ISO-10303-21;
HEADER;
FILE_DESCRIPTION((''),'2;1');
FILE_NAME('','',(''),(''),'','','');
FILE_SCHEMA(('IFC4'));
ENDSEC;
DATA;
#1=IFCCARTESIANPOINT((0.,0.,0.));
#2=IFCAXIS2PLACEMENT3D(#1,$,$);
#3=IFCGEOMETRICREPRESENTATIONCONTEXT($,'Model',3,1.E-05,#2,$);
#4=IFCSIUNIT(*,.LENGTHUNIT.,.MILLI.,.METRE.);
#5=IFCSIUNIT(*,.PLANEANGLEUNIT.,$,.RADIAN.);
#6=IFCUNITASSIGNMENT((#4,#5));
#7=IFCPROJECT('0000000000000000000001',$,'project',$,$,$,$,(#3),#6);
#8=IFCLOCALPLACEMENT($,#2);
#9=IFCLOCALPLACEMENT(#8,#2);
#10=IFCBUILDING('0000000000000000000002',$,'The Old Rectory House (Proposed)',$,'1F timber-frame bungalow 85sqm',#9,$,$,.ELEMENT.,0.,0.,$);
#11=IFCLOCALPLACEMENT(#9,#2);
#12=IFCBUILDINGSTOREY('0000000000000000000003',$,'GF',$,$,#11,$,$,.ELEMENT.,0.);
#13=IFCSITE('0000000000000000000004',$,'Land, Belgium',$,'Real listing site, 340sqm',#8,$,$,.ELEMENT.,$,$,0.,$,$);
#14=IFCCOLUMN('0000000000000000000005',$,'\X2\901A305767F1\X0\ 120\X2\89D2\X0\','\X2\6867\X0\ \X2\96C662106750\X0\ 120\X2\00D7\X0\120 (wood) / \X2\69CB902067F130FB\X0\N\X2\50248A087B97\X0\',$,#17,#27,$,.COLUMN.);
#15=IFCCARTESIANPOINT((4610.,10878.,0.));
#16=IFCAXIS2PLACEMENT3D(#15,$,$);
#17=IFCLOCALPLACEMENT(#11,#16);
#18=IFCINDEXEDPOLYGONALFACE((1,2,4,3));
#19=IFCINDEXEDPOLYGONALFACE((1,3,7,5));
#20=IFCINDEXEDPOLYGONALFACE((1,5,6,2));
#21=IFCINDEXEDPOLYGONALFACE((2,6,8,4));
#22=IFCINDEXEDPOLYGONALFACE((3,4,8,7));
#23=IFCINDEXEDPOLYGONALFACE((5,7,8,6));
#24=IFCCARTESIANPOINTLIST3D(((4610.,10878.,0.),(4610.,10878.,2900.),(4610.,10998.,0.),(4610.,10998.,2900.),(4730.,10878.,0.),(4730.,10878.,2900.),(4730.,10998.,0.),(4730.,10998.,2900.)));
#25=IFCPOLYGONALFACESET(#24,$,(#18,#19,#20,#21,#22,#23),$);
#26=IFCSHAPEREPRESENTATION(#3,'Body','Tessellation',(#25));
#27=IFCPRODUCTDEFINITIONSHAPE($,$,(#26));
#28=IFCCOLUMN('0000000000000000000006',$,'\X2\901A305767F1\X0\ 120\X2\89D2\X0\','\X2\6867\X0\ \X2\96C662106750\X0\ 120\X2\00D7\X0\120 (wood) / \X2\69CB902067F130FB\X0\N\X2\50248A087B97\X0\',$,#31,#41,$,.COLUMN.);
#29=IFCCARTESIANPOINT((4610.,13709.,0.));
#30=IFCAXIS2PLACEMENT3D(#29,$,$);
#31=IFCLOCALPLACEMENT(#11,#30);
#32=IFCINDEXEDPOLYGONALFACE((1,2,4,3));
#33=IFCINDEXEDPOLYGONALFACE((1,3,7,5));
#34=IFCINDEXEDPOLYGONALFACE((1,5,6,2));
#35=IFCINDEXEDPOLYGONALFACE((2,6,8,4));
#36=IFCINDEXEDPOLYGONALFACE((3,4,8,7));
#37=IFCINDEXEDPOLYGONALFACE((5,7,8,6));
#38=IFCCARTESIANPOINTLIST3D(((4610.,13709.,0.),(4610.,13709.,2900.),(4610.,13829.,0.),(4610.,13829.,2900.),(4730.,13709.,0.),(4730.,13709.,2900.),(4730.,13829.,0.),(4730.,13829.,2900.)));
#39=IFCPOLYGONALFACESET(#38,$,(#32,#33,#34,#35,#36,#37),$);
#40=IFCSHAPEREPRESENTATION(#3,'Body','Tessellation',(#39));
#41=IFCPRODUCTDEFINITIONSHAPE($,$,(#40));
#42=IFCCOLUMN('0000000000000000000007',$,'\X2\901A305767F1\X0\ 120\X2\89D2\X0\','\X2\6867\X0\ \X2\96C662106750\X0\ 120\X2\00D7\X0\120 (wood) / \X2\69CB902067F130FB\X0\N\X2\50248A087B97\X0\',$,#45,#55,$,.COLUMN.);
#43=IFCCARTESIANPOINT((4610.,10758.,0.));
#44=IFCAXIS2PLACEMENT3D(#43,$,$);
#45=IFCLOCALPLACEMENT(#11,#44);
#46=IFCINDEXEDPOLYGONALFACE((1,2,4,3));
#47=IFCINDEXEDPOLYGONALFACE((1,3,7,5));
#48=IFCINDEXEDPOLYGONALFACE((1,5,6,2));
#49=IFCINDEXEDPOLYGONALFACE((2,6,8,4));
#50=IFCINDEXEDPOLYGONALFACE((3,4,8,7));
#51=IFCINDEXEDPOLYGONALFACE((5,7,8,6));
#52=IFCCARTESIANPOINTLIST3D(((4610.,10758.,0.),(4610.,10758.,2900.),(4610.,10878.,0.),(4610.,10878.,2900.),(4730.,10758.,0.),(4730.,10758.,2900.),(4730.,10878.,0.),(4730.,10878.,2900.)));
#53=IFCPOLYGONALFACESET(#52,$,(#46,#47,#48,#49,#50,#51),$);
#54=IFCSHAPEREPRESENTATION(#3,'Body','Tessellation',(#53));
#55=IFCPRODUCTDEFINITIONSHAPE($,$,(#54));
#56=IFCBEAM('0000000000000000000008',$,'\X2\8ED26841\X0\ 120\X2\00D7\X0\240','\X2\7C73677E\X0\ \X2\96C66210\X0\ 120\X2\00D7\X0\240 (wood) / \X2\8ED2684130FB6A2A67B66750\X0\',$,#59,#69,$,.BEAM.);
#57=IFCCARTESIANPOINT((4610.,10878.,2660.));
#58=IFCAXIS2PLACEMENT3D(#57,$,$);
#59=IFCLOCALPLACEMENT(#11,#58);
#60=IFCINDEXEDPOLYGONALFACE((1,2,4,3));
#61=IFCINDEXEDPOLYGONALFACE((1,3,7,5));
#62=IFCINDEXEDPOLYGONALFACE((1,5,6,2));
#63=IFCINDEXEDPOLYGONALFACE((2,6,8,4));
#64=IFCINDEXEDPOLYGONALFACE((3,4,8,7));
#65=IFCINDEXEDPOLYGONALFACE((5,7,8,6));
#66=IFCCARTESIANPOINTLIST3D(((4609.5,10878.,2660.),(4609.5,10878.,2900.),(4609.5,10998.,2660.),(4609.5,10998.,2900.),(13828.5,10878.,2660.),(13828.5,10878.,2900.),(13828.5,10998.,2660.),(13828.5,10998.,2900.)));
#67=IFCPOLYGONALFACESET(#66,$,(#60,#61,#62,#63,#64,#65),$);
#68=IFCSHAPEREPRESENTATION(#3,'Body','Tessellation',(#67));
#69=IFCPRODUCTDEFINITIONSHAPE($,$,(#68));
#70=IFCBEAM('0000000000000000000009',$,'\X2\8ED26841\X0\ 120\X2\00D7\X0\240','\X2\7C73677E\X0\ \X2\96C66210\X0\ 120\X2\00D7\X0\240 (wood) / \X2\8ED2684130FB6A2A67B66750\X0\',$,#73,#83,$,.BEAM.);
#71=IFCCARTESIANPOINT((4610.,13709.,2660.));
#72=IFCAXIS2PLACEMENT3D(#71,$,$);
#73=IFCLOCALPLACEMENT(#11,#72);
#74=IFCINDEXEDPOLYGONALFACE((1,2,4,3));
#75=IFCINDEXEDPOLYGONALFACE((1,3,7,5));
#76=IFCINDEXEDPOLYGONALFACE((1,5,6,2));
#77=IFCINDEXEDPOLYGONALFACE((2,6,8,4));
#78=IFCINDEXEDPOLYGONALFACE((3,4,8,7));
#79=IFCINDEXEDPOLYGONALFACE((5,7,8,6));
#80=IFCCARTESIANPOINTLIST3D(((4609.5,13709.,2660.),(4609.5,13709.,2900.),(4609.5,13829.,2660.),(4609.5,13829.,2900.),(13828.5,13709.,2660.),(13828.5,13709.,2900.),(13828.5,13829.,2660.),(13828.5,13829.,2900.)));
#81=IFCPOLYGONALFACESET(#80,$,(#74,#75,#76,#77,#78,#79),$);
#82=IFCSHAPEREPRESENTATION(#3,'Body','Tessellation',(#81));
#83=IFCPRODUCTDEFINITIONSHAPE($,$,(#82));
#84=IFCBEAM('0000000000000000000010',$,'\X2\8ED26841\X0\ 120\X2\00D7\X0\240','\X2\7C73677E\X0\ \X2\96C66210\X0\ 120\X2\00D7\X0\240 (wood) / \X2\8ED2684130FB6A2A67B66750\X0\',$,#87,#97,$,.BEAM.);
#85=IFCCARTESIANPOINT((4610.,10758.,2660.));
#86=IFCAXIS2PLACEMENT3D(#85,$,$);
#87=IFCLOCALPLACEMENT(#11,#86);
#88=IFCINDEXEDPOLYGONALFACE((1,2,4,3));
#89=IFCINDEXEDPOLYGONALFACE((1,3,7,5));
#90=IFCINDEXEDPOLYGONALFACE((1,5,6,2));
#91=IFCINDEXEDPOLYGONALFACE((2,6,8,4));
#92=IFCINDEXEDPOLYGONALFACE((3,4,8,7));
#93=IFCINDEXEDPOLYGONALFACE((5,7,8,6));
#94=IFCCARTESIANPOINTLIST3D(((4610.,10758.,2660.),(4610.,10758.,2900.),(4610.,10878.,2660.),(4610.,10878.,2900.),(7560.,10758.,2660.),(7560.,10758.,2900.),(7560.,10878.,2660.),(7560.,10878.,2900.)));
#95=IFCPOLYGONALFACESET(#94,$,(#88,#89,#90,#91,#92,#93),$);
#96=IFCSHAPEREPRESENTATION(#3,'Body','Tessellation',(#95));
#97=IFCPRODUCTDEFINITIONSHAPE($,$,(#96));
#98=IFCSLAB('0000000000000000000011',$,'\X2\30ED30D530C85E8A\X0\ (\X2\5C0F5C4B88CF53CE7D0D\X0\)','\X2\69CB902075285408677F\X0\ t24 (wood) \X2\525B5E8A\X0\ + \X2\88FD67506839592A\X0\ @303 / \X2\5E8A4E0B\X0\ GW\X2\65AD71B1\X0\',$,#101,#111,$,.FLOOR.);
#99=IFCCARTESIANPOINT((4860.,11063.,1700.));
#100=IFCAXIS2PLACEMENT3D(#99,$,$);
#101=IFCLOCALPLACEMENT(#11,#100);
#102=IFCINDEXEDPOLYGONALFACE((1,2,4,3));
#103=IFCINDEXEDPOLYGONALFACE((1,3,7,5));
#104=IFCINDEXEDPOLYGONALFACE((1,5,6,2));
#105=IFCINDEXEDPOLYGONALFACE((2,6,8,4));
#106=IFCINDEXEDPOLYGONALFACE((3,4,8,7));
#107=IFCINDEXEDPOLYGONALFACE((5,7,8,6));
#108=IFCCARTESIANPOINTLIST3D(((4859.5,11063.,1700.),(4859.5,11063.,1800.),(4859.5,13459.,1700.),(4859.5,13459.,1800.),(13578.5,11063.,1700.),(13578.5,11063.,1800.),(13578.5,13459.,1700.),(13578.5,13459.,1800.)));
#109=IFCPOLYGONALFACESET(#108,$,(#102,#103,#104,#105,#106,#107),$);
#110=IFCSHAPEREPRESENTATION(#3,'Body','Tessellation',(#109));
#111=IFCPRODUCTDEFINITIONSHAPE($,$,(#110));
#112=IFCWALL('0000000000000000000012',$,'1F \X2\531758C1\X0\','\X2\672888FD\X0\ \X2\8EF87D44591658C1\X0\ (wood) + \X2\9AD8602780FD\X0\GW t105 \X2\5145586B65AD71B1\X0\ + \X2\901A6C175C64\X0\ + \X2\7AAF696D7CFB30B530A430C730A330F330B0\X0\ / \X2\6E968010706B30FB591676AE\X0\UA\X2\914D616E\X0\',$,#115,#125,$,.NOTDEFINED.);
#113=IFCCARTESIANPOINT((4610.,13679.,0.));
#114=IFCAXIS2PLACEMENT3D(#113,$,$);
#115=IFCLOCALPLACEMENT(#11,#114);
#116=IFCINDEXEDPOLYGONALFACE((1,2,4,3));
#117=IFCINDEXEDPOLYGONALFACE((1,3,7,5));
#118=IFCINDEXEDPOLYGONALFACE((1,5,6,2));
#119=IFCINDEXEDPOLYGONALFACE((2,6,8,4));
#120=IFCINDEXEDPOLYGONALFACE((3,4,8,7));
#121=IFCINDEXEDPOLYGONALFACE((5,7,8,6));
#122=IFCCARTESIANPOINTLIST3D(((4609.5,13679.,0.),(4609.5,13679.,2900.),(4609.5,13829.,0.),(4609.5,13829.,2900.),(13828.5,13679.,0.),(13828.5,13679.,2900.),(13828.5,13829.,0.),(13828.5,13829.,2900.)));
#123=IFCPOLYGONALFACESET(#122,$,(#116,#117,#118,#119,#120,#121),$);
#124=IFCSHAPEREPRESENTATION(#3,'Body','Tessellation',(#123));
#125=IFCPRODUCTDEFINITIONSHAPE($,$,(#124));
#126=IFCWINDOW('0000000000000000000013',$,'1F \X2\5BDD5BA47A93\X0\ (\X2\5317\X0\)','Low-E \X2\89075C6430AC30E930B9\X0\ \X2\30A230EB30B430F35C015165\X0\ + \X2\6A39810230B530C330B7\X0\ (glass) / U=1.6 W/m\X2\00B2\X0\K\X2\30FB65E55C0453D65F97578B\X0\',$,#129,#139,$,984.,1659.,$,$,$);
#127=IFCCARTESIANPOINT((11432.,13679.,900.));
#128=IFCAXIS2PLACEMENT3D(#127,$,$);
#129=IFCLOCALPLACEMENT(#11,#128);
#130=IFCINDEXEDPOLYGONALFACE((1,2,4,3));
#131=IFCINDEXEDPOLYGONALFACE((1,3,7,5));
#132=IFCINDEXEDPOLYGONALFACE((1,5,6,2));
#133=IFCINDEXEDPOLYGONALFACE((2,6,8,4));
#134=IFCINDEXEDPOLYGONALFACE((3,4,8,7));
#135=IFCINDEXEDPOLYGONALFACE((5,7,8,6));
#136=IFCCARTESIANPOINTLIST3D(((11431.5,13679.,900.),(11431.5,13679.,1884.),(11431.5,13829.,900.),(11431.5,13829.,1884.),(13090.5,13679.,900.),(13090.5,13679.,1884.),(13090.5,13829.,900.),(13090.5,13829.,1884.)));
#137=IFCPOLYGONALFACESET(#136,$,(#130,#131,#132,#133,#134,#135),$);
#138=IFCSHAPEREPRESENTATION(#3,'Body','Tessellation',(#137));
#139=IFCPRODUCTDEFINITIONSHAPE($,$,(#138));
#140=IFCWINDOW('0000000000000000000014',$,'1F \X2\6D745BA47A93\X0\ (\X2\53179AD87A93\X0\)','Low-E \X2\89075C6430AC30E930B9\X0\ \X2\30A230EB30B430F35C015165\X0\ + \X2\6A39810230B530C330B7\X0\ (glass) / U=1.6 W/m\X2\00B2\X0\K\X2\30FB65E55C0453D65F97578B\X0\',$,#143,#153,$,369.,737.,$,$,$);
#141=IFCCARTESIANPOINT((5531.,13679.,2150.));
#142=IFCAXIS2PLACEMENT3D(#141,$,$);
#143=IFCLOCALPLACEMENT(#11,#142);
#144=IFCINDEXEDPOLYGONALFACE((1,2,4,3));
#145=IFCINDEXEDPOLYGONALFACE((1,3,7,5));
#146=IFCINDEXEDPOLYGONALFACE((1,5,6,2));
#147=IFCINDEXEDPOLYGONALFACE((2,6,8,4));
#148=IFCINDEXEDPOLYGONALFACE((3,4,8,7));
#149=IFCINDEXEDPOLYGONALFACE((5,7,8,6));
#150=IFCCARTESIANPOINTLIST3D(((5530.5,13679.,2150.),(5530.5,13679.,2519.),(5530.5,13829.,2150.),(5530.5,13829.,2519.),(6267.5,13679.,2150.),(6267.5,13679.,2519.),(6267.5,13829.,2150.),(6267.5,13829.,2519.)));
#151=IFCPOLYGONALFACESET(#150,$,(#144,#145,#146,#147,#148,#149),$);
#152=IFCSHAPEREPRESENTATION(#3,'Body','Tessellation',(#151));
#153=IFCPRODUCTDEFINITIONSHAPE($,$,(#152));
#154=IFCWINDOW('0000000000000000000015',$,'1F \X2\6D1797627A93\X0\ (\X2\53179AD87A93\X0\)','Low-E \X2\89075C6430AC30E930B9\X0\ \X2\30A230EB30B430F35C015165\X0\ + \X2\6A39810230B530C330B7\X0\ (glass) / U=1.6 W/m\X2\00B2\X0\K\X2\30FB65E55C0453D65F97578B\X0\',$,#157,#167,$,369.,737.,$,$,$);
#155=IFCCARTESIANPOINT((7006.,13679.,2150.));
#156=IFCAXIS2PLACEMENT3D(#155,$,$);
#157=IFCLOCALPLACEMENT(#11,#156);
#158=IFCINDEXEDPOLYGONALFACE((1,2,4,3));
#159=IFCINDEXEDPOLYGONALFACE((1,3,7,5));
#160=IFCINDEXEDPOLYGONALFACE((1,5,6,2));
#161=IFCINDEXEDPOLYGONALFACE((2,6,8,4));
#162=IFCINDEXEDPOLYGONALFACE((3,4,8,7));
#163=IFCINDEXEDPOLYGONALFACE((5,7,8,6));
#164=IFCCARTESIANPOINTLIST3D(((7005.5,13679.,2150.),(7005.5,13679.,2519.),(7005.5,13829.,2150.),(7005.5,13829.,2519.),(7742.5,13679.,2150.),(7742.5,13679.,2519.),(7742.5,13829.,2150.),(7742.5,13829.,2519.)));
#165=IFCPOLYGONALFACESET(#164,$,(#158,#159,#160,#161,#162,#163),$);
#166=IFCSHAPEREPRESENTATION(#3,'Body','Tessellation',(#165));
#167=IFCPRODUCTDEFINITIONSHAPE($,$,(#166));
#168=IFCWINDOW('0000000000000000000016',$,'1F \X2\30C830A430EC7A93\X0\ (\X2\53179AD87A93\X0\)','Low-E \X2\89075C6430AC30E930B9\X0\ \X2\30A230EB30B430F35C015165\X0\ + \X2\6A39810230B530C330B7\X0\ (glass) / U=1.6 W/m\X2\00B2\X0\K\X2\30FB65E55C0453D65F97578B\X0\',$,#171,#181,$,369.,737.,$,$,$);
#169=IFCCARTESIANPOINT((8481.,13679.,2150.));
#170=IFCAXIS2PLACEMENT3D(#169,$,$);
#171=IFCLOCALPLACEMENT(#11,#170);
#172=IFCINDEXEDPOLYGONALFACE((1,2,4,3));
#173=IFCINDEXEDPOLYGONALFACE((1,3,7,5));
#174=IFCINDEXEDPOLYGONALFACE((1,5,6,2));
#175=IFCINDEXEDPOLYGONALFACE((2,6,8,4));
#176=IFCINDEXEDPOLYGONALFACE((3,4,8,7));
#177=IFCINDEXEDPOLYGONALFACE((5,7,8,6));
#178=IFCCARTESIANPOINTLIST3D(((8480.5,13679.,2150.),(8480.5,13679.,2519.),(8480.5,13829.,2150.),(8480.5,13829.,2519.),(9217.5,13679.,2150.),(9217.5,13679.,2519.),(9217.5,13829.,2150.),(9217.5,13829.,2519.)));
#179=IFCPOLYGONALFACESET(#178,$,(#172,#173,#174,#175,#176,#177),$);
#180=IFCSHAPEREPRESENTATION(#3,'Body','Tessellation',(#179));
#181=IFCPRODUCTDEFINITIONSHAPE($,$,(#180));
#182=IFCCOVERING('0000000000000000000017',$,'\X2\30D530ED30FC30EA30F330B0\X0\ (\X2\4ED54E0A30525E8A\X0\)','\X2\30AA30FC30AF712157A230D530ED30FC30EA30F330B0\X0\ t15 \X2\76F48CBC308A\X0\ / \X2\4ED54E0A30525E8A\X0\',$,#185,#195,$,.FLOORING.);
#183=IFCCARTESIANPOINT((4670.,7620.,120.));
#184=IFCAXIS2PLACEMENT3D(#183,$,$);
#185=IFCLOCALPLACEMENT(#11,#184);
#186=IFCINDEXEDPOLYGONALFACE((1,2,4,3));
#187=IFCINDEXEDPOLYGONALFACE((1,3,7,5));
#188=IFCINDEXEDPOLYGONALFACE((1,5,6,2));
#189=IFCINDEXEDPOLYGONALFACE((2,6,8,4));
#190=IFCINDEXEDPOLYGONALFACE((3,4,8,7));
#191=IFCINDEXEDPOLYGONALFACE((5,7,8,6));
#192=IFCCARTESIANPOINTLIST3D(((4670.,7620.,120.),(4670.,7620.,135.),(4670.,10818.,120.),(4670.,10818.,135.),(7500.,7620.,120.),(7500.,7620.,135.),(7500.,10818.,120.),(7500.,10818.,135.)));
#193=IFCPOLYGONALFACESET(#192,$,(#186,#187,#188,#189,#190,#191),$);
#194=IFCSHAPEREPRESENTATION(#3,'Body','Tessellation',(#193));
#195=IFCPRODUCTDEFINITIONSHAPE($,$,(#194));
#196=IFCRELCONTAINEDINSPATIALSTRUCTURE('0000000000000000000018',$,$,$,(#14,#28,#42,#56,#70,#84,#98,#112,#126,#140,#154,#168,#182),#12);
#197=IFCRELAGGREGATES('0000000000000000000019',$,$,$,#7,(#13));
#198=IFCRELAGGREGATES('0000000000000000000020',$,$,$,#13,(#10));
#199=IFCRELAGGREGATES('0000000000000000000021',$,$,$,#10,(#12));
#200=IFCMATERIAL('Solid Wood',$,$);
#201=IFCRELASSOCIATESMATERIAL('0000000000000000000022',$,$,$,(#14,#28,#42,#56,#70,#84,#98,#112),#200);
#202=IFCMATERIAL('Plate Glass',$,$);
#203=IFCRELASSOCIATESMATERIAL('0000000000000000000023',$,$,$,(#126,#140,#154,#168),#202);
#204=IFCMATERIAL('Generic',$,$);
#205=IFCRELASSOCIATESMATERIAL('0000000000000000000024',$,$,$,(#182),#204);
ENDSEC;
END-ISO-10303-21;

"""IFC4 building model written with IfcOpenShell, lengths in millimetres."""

from ifc_helpers import new_model, si_unit, frame, frame_2d, origin, place, context, project, spatial, rectangle, extrude, material, element, fill, save


model = new_model("IFC4")

# Units and contexts
model_context = context("Model", 3, precision=1e-05, world=origin())
ifc_project = project(units=[si_unit("LENGTHUNIT", "METRE", prefix="MILLI"), si_unit("PLANEANGLEUNIT", "RADIAN")], contexts=[model_context])

# Site, building, storey
site_placement = place(None, origin())
site = spatial("IfcSite", under=ifc_project, at=site_placement, Name="Land, Belgium", ObjectType="Real listing site, 340sqm", CompositionType="ELEMENT", RefElevation=0.0)
building_placement = place(site_placement, origin())
building = spatial("IfcBuilding", under=site, at=building_placement, Name="The Old Rectory House (Proposed)", ObjectType="1F timber-frame bungalow 85sqm", CompositionType="ELEMENT", ElevationOfRefHeight=0.0, ElevationOfTerrain=0.0)
storey_placement = place(building_placement, origin())
storey = spatial("IfcBuildingStorey", under=building, at=storey_placement, Name="GF", CompositionType="ELEMENT", Elevation=0.0)

# Columns
ifc_material_1 = material(Name="Solid Wood")
column_1_placement = place(storey_placement, frame((4610.0, 10878.0, 0.0)))
element("IfcColumn", 1, at=column_1_placement, inside=storey, material=ifc_material_1, Name="通し柱 120角", Description="桧 集成材 120×120 (wood) / 構造柱・N値計算", PredefinedType="COLUMN", context=model_context, shape_type="SweptSolid", body=[
    extrude(rectangle(XDim=120.0, YDim=120.0, at=frame_2d((60.0, 60.0))), frame((4610.0, 10878.0, 0.0)), (0.0, 0.0, 1.0), 2900.0),
])
column_2_placement = place(storey_placement, frame((4610.0, 13709.0, 0.0)))
element("IfcColumn", 2, at=column_2_placement, inside=storey, material=ifc_material_1, Name="通し柱 120角", Description="桧 集成材 120×120 (wood) / 構造柱・N値計算", PredefinedType="COLUMN", context=model_context, shape_type="SweptSolid", body=[
    extrude(rectangle(XDim=120.0, YDim=120.0, at=frame_2d((60.0, 60.0))), frame((4610.0, 13709.0, 0.0)), (0.0, 0.0, 1.0), 2900.0),
])
column_3_placement = place(storey_placement, frame((4610.0, 10758.0, 0.0)))
element("IfcColumn", 3, at=column_3_placement, inside=storey, material=ifc_material_1, Name="通し柱 120角", Description="桧 集成材 120×120 (wood) / 構造柱・N値計算", PredefinedType="COLUMN", context=model_context, shape_type="SweptSolid", body=[
    extrude(rectangle(XDim=120.0, YDim=120.0, at=frame_2d((60.0, 60.0))), frame((4610.0, 10758.0, 0.0)), (0.0, 0.0, 1.0), 2900.0),
])

# Beams
beam_1_placement = place(storey_placement, frame((4610.0, 10878.0, 2660.0)))
element("IfcBeam", 4, at=beam_1_placement, inside=storey, material=ifc_material_1, Name="軒桁 120×240", Description="米松 集成 120×240 (wood) / 軒桁・横架材", PredefinedType="BEAM", context=model_context, shape_type="SweptSolid", body=[
    extrude(rectangle(XDim=9219.0, YDim=120.0, at=frame_2d((4609.0, 60.0))), frame((4610.0, 10878.0, 2660.0)), (0.0, 0.0, 1.0), 240.0),
])
beam_2_placement = place(storey_placement, frame((4610.0, 13709.0, 2660.0)))
element("IfcBeam", 5, at=beam_2_placement, inside=storey, material=ifc_material_1, Name="軒桁 120×240", Description="米松 集成 120×240 (wood) / 軒桁・横架材", PredefinedType="BEAM", context=model_context, shape_type="SweptSolid", body=[
    extrude(rectangle(XDim=9219.0, YDim=120.0, at=frame_2d((4609.0, 60.0))), frame((4610.0, 13709.0, 2660.0)), (0.0, 0.0, 1.0), 240.0),
])
beam_3_placement = place(storey_placement, frame((4610.0, 10758.0, 2660.0)))
element("IfcBeam", 6, at=beam_3_placement, inside=storey, material=ifc_material_1, Name="軒桁 120×240", Description="米松 集成 120×240 (wood) / 軒桁・横架材", PredefinedType="BEAM", context=model_context, shape_type="SweptSolid", body=[
    extrude(rectangle(XDim=2950.0, YDim=120.0, at=frame_2d((1475.0, 60.0))), frame((4610.0, 10758.0, 2660.0)), (0.0, 0.0, 1.0), 240.0),
])

# Slab
slab_1_placement = place(storey_placement, frame((4860.0, 11063.0, 1700.0)))
element("IfcSlab", 7, at=slab_1_placement, inside=storey, material=ifc_material_1, Name="ロフト床 (小屋裏収納)", Description="構造用合板 t24 (wood) 剛床 + 製材根太 @303 / 床下 GW断熱", PredefinedType="FLOOR", context=model_context, shape_type="SweptSolid", body=[
    extrude(rectangle(XDim=8719.0, YDim=2396.0, at=frame_2d((4359.0, 1198.0))), frame((4860.0, 11063.0, 1700.0)), (0.0, 0.0, 1.0), 100.0),
])

# Wall, openings, windows
wall_1_placement = place(storey_placement, frame((4610.0, 13679.0, 0.0)))
wall_1 = element("IfcWall", 8, at=wall_1_placement, inside=storey, material=ifc_material_1, Name="1F 北壁", Description="木製 軸組外壁 (wood) + 高性能GW t105 充填断熱 + 通気層 + 窯業系サイディング / 準耐火・外皮UA配慮", PredefinedType="NOTDEFINED", context=model_context, shape_type="SweptSolid", body=[
    extrude(rectangle(XDim=9219.0, YDim=150.0, at=frame_2d((4609.0, 75.0))), frame((4610.0, 13679.0, 0.0)), (0.0, 0.0, 1.0), 2900.0),
])
opening_1_placement = place(storey_placement, frame((11432.0, 13679.0, 900.0)))
opening_1 = element("IfcOpeningElement", 9, at=opening_1_placement, cuts=wall_1, PredefinedType="NOTDEFINED", context=model_context, shape_type="SweptSolid", body=[
    extrude(rectangle(XDim=1659.0, YDim=150.0, at=frame_2d((829.0, 75.0))), frame((11432.0, 13679.0, 900.0)), (0.0, 0.0, 1.0), 984.0),
])
opening_2_placement = place(storey_placement, frame((5531.0, 13679.0, 2150.0)))
opening_2 = element("IfcOpeningElement", 10, at=opening_2_placement, cuts=wall_1, PredefinedType="NOTDEFINED", context=model_context, shape_type="SweptSolid", body=[
    extrude(rectangle(XDim=737.0, YDim=150.0, at=frame_2d((368.0, 75.0))), frame((5531.0, 13679.0, 2150.0)), (0.0, 0.0, 1.0), 369.0),
])
opening_3_placement = place(storey_placement, frame((7006.0, 13679.0, 2150.0)))
opening_3 = element("IfcOpeningElement", 11, at=opening_3_placement, cuts=wall_1, PredefinedType="NOTDEFINED", context=model_context, shape_type="SweptSolid", body=[
    extrude(rectangle(XDim=737.0, YDim=150.0, at=frame_2d((368.0, 75.0))), frame((7006.0, 13679.0, 2150.0)), (0.0, 0.0, 1.0), 369.0),
])
opening_4_placement = place(storey_placement, frame((8481.0, 13679.0, 2150.0)))
opening_4 = element("IfcOpeningElement", 12, at=opening_4_placement, cuts=wall_1, PredefinedType="NOTDEFINED", context=model_context, shape_type="SweptSolid", body=[
    extrude(rectangle(XDim=737.0, YDim=150.0, at=frame_2d((368.0, 75.0))), frame((8481.0, 13679.0, 2150.0)), (0.0, 0.0, 1.0), 369.0),
])
ifc_material_2 = material(Name="Plate Glass")
window_1_placement = place(storey_placement, frame((11432.0, 13679.0, 900.0)))
window_1 = element("IfcWindow", 13, at=window_1_placement, inside=storey, material=ifc_material_2, Name="1F 寝室窓 (北)", Description="Low-E 複層ガラス アルゴン封入 + 樹脂サッシ (glass) / U=1.6 W/m²K・日射取得型", OverallHeight=984.0, OverallWidth=1659.0, context=model_context, shape_type="SweptSolid", body=[
    extrude(rectangle(XDim=1659.0, YDim=150.0, at=frame_2d((829.0, 75.0))), frame((11432.0, 13679.0, 900.0)), (0.0, 0.0, 1.0), 984.0),
])
fill(opening_1, window_1)
window_2_placement = place(storey_placement, frame((5531.0, 13679.0, 2150.0)))
window_2 = element("IfcWindow", 14, at=window_2_placement, inside=storey, material=ifc_material_2, Name="1F 浴室窓 (北高窓)", Description="Low-E 複層ガラス アルゴン封入 + 樹脂サッシ (glass) / U=1.6 W/m²K・日射取得型", OverallHeight=369.0, OverallWidth=737.0, context=model_context, shape_type="SweptSolid", body=[
    extrude(rectangle(XDim=737.0, YDim=150.0, at=frame_2d((368.0, 75.0))), frame((5531.0, 13679.0, 2150.0)), (0.0, 0.0, 1.0), 369.0),
])
fill(opening_2, window_2)
window_3_placement = place(storey_placement, frame((7006.0, 13679.0, 2150.0)))
window_3 = element("IfcWindow", 15, at=window_3_placement, inside=storey, material=ifc_material_2, Name="1F 洗面窓 (北高窓)", Description="Low-E 複層ガラス アルゴン封入 + 樹脂サッシ (glass) / U=1.6 W/m²K・日射取得型", OverallHeight=369.0, OverallWidth=737.0, context=model_context, shape_type="SweptSolid", body=[
    extrude(rectangle(XDim=737.0, YDim=150.0, at=frame_2d((368.0, 75.0))), frame((7006.0, 13679.0, 2150.0)), (0.0, 0.0, 1.0), 369.0),
])
fill(opening_3, window_3)
window_4_placement = place(storey_placement, frame((8481.0, 13679.0, 2150.0)))
window_4 = element("IfcWindow", 16, at=window_4_placement, inside=storey, material=ifc_material_2, Name="1F トイレ窓 (北高窓)", Description="Low-E 複層ガラス アルゴン封入 + 樹脂サッシ (glass) / U=1.6 W/m²K・日射取得型", OverallHeight=369.0, OverallWidth=737.0, context=model_context, shape_type="SweptSolid", body=[
    extrude(rectangle(XDim=737.0, YDim=150.0, at=frame_2d((368.0, 75.0))), frame((8481.0, 13679.0, 2150.0)), (0.0, 0.0, 1.0), 369.0),
])
fill(opening_4, window_4)

# Covering
ifc_material_3 = material(Name="Generic")
covering_1_placement = place(storey_placement, frame((4670.0, 7620.0, 120.0)))
element("IfcCovering", 17, at=covering_1_placement, inside=storey, material=ifc_material_3, Name="フローリング (仕上げ床)", Description="オーク無垢フローリング t15 直貼り / 仕上げ床", PredefinedType="FLOORING", context=model_context, shape_type="SweptSolid", body=[
    extrude(rectangle(XDim=2830.0, YDim=3198.0, at=frame_2d((1415.0, 1599.0))), frame((4670.0, 7620.0, 120.0)), (0.0, 0.0, 1.0), 15.0),
])

save(model, "model.ifc")
